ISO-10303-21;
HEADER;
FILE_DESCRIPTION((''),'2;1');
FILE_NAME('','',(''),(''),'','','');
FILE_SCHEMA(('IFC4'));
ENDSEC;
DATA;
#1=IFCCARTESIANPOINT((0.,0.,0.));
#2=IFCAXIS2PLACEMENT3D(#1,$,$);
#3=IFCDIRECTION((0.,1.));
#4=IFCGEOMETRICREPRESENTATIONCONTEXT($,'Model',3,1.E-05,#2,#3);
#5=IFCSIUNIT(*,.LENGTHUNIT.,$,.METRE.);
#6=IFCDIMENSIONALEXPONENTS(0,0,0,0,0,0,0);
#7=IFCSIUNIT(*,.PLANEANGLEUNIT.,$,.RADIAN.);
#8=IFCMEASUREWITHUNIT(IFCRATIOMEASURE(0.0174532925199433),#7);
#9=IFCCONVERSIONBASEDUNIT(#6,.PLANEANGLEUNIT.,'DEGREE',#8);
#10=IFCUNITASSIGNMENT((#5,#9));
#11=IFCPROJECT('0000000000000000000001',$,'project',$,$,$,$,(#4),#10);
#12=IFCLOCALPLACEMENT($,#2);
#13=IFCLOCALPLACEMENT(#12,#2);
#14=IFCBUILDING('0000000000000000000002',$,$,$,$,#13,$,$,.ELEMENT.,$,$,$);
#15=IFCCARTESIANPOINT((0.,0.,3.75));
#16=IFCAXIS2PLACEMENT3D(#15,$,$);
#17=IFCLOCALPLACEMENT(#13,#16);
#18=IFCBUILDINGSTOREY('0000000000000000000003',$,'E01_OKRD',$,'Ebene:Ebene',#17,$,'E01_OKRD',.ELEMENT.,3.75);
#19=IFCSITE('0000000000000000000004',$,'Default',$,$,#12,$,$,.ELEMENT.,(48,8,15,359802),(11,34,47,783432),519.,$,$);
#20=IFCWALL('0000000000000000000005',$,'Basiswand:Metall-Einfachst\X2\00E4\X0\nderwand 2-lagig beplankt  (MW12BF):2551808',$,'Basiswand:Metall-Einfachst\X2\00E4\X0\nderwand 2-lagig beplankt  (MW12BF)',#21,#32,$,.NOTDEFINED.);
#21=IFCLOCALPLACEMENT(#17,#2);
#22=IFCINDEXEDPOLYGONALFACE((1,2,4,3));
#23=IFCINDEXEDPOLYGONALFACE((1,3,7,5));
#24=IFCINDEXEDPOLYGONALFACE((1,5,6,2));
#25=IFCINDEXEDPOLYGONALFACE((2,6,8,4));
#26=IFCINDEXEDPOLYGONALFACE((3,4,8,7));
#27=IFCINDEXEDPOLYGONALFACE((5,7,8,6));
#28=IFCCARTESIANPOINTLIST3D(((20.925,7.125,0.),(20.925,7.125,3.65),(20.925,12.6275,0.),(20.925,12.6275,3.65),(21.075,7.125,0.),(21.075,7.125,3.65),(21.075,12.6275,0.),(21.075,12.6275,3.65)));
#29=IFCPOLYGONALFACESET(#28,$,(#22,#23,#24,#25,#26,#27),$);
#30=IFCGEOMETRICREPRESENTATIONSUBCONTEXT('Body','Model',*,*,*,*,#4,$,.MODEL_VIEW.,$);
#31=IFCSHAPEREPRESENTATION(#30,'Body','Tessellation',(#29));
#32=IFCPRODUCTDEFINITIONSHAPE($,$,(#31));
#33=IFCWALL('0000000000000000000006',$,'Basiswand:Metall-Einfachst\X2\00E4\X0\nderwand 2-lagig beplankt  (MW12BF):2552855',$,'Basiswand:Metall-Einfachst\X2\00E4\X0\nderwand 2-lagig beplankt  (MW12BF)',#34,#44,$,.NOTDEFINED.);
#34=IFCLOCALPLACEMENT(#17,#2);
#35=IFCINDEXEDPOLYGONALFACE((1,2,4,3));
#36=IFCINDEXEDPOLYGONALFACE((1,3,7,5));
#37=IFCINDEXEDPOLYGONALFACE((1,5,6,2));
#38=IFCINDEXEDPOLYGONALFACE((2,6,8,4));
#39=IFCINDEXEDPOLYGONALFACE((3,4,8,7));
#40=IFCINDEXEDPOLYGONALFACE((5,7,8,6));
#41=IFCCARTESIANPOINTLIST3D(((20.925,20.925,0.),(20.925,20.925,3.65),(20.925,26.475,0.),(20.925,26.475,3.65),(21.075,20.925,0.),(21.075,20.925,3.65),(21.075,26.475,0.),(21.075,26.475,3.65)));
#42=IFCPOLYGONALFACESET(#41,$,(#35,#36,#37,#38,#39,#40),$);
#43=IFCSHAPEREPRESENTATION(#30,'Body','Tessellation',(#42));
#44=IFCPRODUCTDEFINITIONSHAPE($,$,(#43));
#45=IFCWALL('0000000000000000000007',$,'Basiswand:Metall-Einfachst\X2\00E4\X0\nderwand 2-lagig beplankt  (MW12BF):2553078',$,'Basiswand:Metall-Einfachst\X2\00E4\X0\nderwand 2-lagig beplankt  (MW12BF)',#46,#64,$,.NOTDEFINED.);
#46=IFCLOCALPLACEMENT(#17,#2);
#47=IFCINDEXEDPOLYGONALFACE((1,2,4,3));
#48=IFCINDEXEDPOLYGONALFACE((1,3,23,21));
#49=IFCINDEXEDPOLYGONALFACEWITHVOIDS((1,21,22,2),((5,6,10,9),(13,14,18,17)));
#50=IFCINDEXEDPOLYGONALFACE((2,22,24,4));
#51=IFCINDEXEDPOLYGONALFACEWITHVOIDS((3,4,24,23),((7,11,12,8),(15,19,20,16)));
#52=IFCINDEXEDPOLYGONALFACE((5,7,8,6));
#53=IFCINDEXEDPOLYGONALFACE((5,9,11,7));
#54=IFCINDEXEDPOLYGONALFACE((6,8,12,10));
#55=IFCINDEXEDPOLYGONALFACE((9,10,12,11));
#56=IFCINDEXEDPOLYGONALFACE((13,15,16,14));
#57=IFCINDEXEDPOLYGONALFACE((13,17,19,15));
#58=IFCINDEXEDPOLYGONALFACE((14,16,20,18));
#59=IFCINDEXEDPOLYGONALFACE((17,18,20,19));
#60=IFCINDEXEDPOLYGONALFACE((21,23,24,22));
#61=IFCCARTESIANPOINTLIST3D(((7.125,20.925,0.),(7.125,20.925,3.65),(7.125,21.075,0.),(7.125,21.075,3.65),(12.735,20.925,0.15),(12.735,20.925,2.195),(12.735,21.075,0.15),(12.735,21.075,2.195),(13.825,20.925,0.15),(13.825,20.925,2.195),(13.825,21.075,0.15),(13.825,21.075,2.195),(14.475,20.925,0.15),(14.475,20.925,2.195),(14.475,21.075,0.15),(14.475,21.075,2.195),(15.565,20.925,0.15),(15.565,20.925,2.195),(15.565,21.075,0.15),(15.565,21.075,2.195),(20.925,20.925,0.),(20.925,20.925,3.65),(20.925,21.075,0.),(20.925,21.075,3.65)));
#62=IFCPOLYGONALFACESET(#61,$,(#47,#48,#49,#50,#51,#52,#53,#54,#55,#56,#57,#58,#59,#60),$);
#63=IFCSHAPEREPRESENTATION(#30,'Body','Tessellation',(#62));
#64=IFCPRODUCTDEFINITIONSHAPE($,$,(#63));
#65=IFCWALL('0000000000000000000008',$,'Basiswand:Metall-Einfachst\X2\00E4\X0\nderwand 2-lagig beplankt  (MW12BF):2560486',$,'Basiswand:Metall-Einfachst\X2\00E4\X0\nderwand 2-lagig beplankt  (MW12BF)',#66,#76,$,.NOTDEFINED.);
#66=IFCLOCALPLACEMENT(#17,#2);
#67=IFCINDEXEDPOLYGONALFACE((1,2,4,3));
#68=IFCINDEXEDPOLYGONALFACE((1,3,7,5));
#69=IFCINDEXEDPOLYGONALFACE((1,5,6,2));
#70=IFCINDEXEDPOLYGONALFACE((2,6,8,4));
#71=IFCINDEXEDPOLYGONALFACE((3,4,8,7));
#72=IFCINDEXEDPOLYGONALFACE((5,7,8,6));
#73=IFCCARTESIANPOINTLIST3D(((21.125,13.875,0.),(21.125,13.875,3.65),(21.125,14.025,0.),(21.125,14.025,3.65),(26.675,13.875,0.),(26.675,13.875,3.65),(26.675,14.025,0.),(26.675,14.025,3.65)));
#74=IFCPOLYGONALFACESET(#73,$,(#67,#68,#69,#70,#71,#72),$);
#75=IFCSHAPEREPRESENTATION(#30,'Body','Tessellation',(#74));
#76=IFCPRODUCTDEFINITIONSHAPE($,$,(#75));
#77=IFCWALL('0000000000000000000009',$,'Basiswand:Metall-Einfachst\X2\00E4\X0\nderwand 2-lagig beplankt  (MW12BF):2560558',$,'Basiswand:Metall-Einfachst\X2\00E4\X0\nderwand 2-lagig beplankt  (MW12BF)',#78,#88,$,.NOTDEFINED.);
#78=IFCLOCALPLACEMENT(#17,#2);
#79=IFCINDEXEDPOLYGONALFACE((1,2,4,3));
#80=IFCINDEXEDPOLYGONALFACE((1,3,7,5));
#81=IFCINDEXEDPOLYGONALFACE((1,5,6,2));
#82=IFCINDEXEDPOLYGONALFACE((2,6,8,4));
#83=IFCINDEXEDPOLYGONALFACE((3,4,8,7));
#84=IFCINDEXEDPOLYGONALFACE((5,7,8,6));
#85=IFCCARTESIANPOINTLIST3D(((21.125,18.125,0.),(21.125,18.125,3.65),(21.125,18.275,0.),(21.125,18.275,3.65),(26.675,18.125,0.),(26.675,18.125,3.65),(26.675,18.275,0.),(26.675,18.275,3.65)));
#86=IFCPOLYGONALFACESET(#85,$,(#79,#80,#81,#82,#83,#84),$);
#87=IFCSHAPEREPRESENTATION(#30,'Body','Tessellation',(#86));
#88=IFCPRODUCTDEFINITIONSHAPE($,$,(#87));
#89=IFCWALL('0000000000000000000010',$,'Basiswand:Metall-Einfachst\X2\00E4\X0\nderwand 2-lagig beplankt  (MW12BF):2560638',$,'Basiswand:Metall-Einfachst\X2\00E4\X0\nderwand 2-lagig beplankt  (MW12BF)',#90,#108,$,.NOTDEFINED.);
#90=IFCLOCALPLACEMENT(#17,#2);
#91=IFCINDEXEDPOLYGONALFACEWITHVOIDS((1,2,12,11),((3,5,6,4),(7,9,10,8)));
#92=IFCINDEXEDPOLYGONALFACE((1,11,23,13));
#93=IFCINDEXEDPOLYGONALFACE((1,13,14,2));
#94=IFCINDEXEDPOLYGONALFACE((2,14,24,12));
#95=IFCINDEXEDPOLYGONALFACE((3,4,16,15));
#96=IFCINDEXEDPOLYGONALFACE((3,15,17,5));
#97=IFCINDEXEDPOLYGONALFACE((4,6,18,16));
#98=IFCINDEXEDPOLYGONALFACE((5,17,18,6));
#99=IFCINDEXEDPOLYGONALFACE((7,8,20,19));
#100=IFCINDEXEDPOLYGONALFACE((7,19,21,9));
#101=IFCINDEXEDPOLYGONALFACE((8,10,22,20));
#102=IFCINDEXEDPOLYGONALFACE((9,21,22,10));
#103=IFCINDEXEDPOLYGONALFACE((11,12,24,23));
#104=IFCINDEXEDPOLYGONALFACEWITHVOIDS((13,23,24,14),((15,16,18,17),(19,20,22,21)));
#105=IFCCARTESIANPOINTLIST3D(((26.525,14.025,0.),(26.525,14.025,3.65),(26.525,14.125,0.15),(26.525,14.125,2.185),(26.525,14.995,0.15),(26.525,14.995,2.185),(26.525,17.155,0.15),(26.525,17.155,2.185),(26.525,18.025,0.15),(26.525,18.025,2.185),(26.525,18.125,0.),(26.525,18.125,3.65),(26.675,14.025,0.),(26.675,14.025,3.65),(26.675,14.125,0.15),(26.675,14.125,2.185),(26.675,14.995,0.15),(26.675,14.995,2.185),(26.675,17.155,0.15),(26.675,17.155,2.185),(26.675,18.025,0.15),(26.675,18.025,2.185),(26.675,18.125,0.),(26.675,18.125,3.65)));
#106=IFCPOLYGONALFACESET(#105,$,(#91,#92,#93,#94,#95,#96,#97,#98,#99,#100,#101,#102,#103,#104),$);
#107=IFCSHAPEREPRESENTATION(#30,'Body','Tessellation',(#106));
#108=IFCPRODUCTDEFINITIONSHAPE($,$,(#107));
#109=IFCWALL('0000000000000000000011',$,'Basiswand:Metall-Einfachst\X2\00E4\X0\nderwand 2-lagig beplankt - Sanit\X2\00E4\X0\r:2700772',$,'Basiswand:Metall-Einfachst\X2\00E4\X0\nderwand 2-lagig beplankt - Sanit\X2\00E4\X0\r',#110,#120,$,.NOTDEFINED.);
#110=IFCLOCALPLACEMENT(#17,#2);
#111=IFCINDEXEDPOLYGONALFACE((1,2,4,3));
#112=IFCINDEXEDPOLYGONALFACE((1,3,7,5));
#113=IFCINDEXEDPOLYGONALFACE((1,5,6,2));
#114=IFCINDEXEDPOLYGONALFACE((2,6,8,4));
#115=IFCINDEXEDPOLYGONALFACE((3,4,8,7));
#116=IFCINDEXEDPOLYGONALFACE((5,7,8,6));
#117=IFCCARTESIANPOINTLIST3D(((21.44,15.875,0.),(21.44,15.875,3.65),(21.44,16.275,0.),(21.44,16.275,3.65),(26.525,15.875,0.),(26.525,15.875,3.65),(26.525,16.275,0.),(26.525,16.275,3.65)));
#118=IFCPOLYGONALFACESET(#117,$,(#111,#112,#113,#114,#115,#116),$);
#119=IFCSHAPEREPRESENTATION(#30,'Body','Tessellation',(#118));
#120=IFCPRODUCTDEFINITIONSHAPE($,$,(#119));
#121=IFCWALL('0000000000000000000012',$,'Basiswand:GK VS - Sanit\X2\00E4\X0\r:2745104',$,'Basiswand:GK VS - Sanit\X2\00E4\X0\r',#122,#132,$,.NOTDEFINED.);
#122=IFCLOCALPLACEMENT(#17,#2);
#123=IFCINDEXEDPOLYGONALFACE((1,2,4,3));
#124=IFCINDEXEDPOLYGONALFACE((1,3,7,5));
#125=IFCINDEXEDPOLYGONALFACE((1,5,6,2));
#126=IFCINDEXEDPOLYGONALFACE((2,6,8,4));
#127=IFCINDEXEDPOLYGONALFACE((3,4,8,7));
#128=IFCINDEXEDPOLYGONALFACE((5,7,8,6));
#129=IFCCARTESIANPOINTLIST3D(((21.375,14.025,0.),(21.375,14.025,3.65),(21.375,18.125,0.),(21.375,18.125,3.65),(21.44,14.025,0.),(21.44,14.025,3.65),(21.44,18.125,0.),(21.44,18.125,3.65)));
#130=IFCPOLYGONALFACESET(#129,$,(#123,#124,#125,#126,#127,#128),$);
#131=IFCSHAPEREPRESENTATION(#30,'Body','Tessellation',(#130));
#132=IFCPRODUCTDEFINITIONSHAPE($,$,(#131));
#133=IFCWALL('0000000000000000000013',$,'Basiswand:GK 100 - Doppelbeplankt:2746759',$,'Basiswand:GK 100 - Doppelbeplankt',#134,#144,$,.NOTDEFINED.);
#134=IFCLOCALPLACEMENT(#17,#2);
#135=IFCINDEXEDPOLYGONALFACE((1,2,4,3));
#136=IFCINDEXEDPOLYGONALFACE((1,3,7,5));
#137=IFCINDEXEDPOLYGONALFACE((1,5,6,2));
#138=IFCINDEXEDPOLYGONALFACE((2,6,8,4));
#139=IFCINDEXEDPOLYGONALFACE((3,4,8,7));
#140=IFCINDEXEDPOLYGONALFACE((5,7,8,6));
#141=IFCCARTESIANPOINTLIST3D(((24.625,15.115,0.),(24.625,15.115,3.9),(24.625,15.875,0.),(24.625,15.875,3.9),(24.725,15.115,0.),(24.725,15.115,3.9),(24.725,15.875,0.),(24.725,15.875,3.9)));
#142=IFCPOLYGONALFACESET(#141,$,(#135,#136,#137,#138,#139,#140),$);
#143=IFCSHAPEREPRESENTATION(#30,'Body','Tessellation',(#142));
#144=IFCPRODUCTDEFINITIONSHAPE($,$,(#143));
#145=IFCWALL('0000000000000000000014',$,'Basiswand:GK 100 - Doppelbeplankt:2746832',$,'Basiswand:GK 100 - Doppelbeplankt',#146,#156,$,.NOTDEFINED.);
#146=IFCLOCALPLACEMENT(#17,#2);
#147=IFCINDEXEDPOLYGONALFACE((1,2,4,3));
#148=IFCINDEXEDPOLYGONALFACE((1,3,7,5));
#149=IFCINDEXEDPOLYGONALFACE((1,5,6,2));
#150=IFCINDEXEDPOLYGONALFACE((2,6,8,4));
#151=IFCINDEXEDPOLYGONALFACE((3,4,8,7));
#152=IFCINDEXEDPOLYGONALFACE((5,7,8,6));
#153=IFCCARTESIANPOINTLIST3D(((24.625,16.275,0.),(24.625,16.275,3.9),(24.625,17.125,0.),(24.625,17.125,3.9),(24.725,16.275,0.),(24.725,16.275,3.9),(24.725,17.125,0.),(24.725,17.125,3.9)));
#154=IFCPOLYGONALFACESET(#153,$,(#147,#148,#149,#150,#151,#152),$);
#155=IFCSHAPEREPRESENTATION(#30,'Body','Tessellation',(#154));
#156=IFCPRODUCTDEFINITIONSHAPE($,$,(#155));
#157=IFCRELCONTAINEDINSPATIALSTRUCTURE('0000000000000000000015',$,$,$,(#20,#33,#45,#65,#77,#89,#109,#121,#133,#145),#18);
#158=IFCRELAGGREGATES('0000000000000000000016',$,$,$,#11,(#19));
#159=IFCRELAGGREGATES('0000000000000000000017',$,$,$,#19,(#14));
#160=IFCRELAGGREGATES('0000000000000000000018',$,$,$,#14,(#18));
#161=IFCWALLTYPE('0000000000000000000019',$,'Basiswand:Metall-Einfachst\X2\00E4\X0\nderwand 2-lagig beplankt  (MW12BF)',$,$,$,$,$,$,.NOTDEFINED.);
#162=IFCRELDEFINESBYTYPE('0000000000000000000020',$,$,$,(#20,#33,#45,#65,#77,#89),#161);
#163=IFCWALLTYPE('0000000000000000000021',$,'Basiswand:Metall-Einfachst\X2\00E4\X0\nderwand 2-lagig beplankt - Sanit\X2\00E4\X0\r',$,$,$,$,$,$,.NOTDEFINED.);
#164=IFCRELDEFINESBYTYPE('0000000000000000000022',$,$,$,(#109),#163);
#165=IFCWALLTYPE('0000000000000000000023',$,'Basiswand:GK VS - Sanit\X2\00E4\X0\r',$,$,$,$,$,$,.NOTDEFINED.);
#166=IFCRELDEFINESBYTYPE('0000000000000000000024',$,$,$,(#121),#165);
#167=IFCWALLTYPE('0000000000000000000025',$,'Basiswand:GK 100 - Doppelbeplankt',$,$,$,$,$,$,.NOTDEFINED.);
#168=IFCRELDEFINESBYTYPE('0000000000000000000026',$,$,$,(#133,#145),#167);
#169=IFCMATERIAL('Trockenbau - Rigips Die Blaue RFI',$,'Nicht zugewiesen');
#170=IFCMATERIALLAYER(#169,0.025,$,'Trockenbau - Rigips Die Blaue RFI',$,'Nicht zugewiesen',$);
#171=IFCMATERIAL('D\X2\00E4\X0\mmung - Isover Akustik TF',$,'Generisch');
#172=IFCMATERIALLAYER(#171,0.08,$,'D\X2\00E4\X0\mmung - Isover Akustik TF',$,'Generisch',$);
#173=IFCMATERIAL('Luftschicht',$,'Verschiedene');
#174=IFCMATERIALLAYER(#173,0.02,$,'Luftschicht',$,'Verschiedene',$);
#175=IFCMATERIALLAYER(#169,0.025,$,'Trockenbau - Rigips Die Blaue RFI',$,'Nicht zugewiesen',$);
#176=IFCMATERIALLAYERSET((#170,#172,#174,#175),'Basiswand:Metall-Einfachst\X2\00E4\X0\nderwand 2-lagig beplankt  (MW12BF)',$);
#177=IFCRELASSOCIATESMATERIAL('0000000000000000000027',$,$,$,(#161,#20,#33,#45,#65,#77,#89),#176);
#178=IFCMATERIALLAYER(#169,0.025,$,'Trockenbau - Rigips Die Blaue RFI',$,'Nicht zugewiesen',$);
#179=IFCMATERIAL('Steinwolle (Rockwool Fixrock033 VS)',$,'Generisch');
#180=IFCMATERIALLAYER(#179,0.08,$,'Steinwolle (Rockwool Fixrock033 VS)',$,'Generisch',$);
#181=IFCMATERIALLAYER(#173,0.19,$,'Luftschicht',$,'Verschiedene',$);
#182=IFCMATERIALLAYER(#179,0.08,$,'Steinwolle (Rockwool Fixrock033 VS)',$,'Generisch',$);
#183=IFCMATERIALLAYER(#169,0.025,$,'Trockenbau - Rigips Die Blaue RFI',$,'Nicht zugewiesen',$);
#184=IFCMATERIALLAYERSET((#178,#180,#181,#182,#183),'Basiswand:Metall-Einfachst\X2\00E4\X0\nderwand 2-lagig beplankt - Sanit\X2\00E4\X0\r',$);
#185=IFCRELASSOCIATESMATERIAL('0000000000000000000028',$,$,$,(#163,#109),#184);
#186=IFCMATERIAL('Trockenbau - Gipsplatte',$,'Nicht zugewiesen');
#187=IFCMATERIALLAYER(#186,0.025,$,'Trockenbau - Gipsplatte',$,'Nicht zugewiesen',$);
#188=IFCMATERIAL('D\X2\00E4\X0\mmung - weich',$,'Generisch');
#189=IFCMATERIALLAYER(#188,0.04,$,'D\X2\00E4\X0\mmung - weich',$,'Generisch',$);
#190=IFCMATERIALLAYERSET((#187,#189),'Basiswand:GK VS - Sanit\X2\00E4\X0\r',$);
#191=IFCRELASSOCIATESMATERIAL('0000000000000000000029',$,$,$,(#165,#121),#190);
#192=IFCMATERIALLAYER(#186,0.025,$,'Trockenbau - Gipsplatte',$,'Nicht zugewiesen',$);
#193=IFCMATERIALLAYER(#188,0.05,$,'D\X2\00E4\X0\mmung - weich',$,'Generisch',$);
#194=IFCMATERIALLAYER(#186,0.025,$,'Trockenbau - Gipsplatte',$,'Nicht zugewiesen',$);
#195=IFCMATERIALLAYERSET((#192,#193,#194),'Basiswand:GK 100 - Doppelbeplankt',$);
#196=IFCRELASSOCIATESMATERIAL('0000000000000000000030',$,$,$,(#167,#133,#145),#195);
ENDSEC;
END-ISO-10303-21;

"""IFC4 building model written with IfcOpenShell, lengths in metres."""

from ifc_helpers import new_model, entity, si_unit, converted_unit, direction, frame, frame_2d, origin, place, context, subcontext, project, spatial, rectangle, extrude, material, layer, layer_set, layer_usage, type_object, element, save


model = new_model("IFC4")

# Units and contexts
model_context = context("Model", 3, precision=1e-05, world=origin(), true_north=direction((0.0, 1.0)))
body_context = subcontext(model_context, "Body", "Model", "MODEL_VIEW")
ifc_project = project(units=[si_unit("LENGTHUNIT", "METRE"), converted_unit("PLANEANGLEUNIT", "DEGREE", entity("IfcRatioMeasure", 0.0174532925199433), si_unit("PLANEANGLEUNIT", "RADIAN"), dimensions=[0, 0, 0, 0, 0, 0, 0])], contexts=[model_context])

# Site, building, storey
site_placement = place(None, frame((0.0, 0.0, 0.0)))
site = spatial("IfcSite", under=ifc_project, at=site_placement, Name="Default", CompositionType="ELEMENT", RefLatitude=(48, 8, 15, 359802), RefLongitude=(11, 34, 47, 783432), RefElevation=519.0)
building_placement = place(site_placement, origin())
building = spatial("IfcBuilding", under=site, at=building_placement, CompositionType="ELEMENT")
storey_placement = place(building_placement, frame((0.0, 0.0, 3.75)))
storey = spatial("IfcBuildingStorey", under=building, at=storey_placement, Name="E01_OKRD", ObjectType="Ebene:Ebene", LongName="E01_OKRD", CompositionType="ELEMENT", Elevation=3.75)

# Walls
ifc_material_1 = material(Name="Trockenbau - Rigips Die Blaue RFI", Category="Nicht zugewiesen")
ifc_layer_1 = layer(ifc_material_1, 0.025, Name="Trockenbau - Rigips Die Blaue RFI", Category="Nicht zugewiesen")
ifc_material_2 = material(Name="Dämmung - Isover Akustik TF", Category="Generisch")
ifc_layer_2 = layer(ifc_material_2, 0.08, Name="Dämmung - Isover Akustik TF", Category="Generisch")
ifc_material_3 = material(Name="Luftschicht", Category="Verschiedene")
ifc_layer_3 = layer(ifc_material_3, 0.02, Name="Luftschicht", Category="Verschiedene")
ifc_layer_4 = layer(ifc_material_1, 0.025, Name="Trockenbau - Rigips Die Blaue RFI", Category="Nicht zugewiesen")
ifc_layer_set_1 = layer_set([ifc_layer_1, ifc_layer_2, ifc_layer_3, ifc_layer_4], Name="Basiswand:Metall-Einfachständerwand 2-lagig beplankt  (MW12BF)")
ifc_layer_usage_1 = layer_usage(ifc_layer_set_1, "AXIS2", "NEGATIVE", 0.075)
wall_type_1 = type_object("IfcWallType", Name="Basiswand:Metall-Einfachständerwand 2-lagig beplankt  (MW12BF)", PredefinedType="NOTDEFINED", material=ifc_layer_set_1)
wall_1_placement = place(storey_placement, frame((21.0, 7.125, 0.0), z_axis=(0.0, 0.0, 1.0), x_axis=(0.0, 1.0, 0.0)))
element("IfcWall", 1, at=wall_1_placement, inside=storey, type_object=wall_type_1, material=ifc_layer_usage_1, Name="Basiswand:Metall-Einfachständerwand 2-lagig beplankt  (MW12BF):2551808", ObjectType="Basiswand:Metall-Einfachständerwand 2-lagig beplankt  (MW12BF)", PredefinedType="NOTDEFINED", context=body_context, shape_type="SweptSolid", body=[
    extrude(rectangle(XDim=5.5025, YDim=0.15, at=frame_2d((2.7513, 0.0), x_axis=(-1.0, 0.0))), origin(), (0.0, 0.0, 1.0), 3.65),
])
ifc_layer_usage_2 = layer_usage(ifc_layer_set_1, "AXIS2", "NEGATIVE", 0.075)
wall_2_placement = place(storey_placement, frame((21.0, 20.925, 0.0), z_axis=(0.0, 0.0, 1.0), x_axis=(0.0, 1.0, 0.0)))
element("IfcWall", 2, at=wall_2_placement, inside=storey, type_object=wall_type_1, material=ifc_layer_usage_2, Name="Basiswand:Metall-Einfachständerwand 2-lagig beplankt  (MW12BF):2552855", ObjectType="Basiswand:Metall-Einfachständerwand 2-lagig beplankt  (MW12BF)", PredefinedType="NOTDEFINED", context=body_context, shape_type="SweptSolid", body=[
    extrude(rectangle(XDim=5.55, YDim=0.15, at=frame_2d((2.775, 0.0), x_axis=(-1.0, 0.0))), origin(), (0.0, 0.0, 1.0), 3.65),
])

# Wall, openings
ifc_layer_usage_3 = layer_usage(ifc_layer_set_1, "AXIS2", "NEGATIVE", 0.075)
wall_3_placement = place(storey_placement, frame((20.925, 21.0, 0.0), z_axis=(0.0, 0.0, 1.0), x_axis=(-1.0, 0.0, 0.0)))
wall_3 = element("IfcWall", 3, at=wall_3_placement, inside=storey, type_object=wall_type_1, material=ifc_layer_usage_3, Name="Basiswand:Metall-Einfachständerwand 2-lagig beplankt  (MW12BF):2553078", ObjectType="Basiswand:Metall-Einfachständerwand 2-lagig beplankt  (MW12BF)", PredefinedType="NOTDEFINED", context=body_context, shape_type="SweptSolid", body=[
    extrude(rectangle(XDim=13.8, YDim=0.15, at=frame_2d((6.9, 0.0), x_axis=(-1.0, 0.0))), origin(), (0.0, 0.0, 1.0), 3.65),
])
opening_1_placement = place(wall_3_placement, frame((8.19, 0.075, 0.15)))
element("IfcOpeningElement", 4, at=opening_1_placement, cuts=wall_3, ObjectType="Opening", PredefinedType="OPENING", context=body_context, shape_type="SweptSolid", body=[
    extrude(rectangle(XDim=2.045, YDim=1.09, at=frame_2d((1.0225, 0.545), x_axis=(-1.0, 0.0))), frame((0.0, 0.0, 0.0), z_axis=(0.0, -1.0, 0.0), x_axis=(0.0, 0.0, 1.0)), (0.0, 0.0, 1.0), 0.15),
])
opening_2_placement = place(wall_3_placement, frame((6.45, 0.075, 0.15)))
element("IfcOpeningElement", 5, at=opening_2_placement, cuts=wall_3, ObjectType="Opening", PredefinedType="OPENING", context=body_context, shape_type="SweptSolid", body=[
    extrude(rectangle(XDim=2.045, YDim=1.09, at=frame_2d((1.0225, 0.545), x_axis=(-1.0, 0.0))), frame((0.0, 0.0, 0.0), z_axis=(0.0, -1.0, 0.0), x_axis=(0.0, 0.0, 1.0)), (0.0, 0.0, 1.0), 0.15),
])

# Walls
ifc_layer_usage_4 = layer_usage(ifc_layer_set_1, "AXIS2", "POSITIVE", -0.075)
wall_4_placement = place(storey_placement, frame((21.125, 13.95, 0.0)))
element("IfcWall", 6, at=wall_4_placement, inside=storey, type_object=wall_type_1, material=ifc_layer_usage_4, Name="Basiswand:Metall-Einfachständerwand 2-lagig beplankt  (MW12BF):2560486", ObjectType="Basiswand:Metall-Einfachständerwand 2-lagig beplankt  (MW12BF)", PredefinedType="NOTDEFINED", context=body_context, shape_type="SweptSolid", body=[
    extrude(rectangle(XDim=5.55, YDim=0.15, at=frame_2d((2.775, 0.0), x_axis=(-1.0, 0.0))), origin(), (0.0, 0.0, 1.0), 3.65),
])
ifc_layer_usage_5 = layer_usage(ifc_layer_set_1, "AXIS2", "NEGATIVE", 0.075)
wall_5_placement = place(storey_placement, frame((21.125, 18.2, 0.0)))
element("IfcWall", 7, at=wall_5_placement, inside=storey, type_object=wall_type_1, material=ifc_layer_usage_5, Name="Basiswand:Metall-Einfachständerwand 2-lagig beplankt  (MW12BF):2560558", ObjectType="Basiswand:Metall-Einfachständerwand 2-lagig beplankt  (MW12BF)", PredefinedType="NOTDEFINED", context=body_context, shape_type="SweptSolid", body=[
    extrude(rectangle(XDim=5.55, YDim=0.15, at=frame_2d((2.775, 0.0), x_axis=(-1.0, 0.0))), origin(), (0.0, 0.0, 1.0), 3.65),
])

# Wall, openings
ifc_layer_usage_6 = layer_usage(ifc_layer_set_1, "AXIS2", "NEGATIVE", 0.075)
wall_6_placement = place(storey_placement, frame((26.6, 18.125, 0.0), z_axis=(0.0, 0.0, 1.0), x_axis=(0.0, -1.0, 0.0)))
wall_6 = element("IfcWall", 8, at=wall_6_placement, inside=storey, type_object=wall_type_1, material=ifc_layer_usage_6, Name="Basiswand:Metall-Einfachständerwand 2-lagig beplankt  (MW12BF):2560638", ObjectType="Basiswand:Metall-Einfachständerwand 2-lagig beplankt  (MW12BF)", PredefinedType="NOTDEFINED", context=body_context, shape_type="SweptSolid", body=[
    extrude(rectangle(XDim=4.1, YDim=0.15, at=frame_2d((2.05, 0.0), x_axis=(-1.0, 0.0))), origin(), (0.0, 0.0, 1.0), 3.65),
])
opening_3_placement = place(wall_6_placement, frame((4.0, 0.075, 0.15)))
element("IfcOpeningElement", 9, at=opening_3_placement, cuts=wall_6, ObjectType="Opening", PredefinedType="OPENING", context=body_context, shape_type="SweptSolid", body=[
    extrude(rectangle(XDim=2.035, YDim=0.87, at=frame_2d((1.0175, 0.435), x_axis=(-1.0, 0.0))), frame((0.0, 0.0, 0.0), z_axis=(0.0, -1.0, 0.0), x_axis=(0.0, 0.0, 1.0)), (0.0, 0.0, 1.0), 0.15),
])
opening_4_placement = place(wall_6_placement, frame((0.97, 0.075, 0.15)))
element("IfcOpeningElement", 10, at=opening_4_placement, cuts=wall_6, ObjectType="Opening", PredefinedType="OPENING", context=body_context, shape_type="SweptSolid", body=[
    extrude(rectangle(XDim=2.035, YDim=0.87, at=frame_2d((1.0175, 0.435), x_axis=(-1.0, 0.0))), frame((0.0, 0.0, 0.0), z_axis=(0.0, -1.0, 0.0), x_axis=(0.0, 0.0, 1.0)), (0.0, 0.0, 1.0), 0.15),
])

# Walls
ifc_layer_5 = layer(ifc_material_1, 0.025, Name="Trockenbau - Rigips Die Blaue RFI", Category="Nicht zugewiesen")
ifc_material_4 = material(Name="Steinwolle (Rockwool Fixrock033 VS)", Category="Generisch")
ifc_layer_6 = layer(ifc_material_4, 0.08, Name="Steinwolle (Rockwool Fixrock033 VS)", Category="Generisch")
ifc_layer_7 = layer(ifc_material_3, 0.19, Name="Luftschicht", Category="Verschiedene")
ifc_layer_8 = layer(ifc_material_4, 0.08, Name="Steinwolle (Rockwool Fixrock033 VS)", Category="Generisch")
ifc_layer_9 = layer(ifc_material_1, 0.025, Name="Trockenbau - Rigips Die Blaue RFI", Category="Nicht zugewiesen")
ifc_layer_set_2 = layer_set([ifc_layer_5, ifc_layer_6, ifc_layer_7, ifc_layer_8, ifc_layer_9], Name="Basiswand:Metall-Einfachständerwand 2-lagig beplankt - Sanitär")
ifc_layer_usage_7 = layer_usage(ifc_layer_set_2, "AXIS2", "NEGATIVE", 0.2)
wall_type_2 = type_object("IfcWallType", Name="Basiswand:Metall-Einfachständerwand 2-lagig beplankt - Sanitär", PredefinedType="NOTDEFINED", material=ifc_layer_set_2)
wall_7_placement = place(storey_placement, frame((21.44, 16.075, 0.0)))
element("IfcWall", 11, at=wall_7_placement, inside=storey, type_object=wall_type_2, material=ifc_layer_usage_7, Name="Basiswand:Metall-Einfachständerwand 2-lagig beplankt - Sanitär:2700772", ObjectType="Basiswand:Metall-Einfachständerwand 2-lagig beplankt - Sanitär", PredefinedType="NOTDEFINED", context=body_context, shape_type="SweptSolid", body=[
    extrude(rectangle(XDim=5.085, YDim=0.4, at=frame_2d((2.5425, 0.0), x_axis=(-1.0, 0.0))), origin(), (0.0, 0.0, 1.0), 3.65),
])
ifc_material_5 = material(Name="Trockenbau - Gipsplatte", Category="Nicht zugewiesen")
ifc_layer_10 = layer(ifc_material_5, 0.025, Name="Trockenbau - Gipsplatte", Category="Nicht zugewiesen")
ifc_material_6 = material(Name="Dämmung - weich", Category="Generisch")
ifc_layer_11 = layer(ifc_material_6, 0.04, Name="Dämmung - weich", Category="Generisch")
ifc_layer_set_3 = layer_set([ifc_layer_10, ifc_layer_11], Name="Basiswand:GK VS - Sanitär")
ifc_layer_usage_8 = layer_usage(ifc_layer_set_3, "AXIS2", "NEGATIVE", 0.0325)
wall_type_3 = type_object("IfcWallType", Name="Basiswand:GK VS - Sanitär", PredefinedType="NOTDEFINED", material=ifc_layer_set_3)
wall_8_placement = place(storey_placement, frame((21.4075, 18.125, 0.0), z_axis=(0.0, 0.0, 1.0), x_axis=(0.0, -1.0, 0.0)))
element("IfcWall", 12, at=wall_8_placement, inside=storey, type_object=wall_type_3, material=ifc_layer_usage_8, Name="Basiswand:GK VS - Sanitär:2745104", ObjectType="Basiswand:GK VS - Sanitär", PredefinedType="NOTDEFINED", context=body_context, shape_type="SweptSolid", body=[
    extrude(rectangle(XDim=4.1, YDim=0.065, at=frame_2d((2.05, 0.0), x_axis=(-1.0, 0.0))), origin(), (0.0, 0.0, 1.0), 3.65),
])
ifc_layer_12 = layer(ifc_material_5, 0.025, Name="Trockenbau - Gipsplatte", Category="Nicht zugewiesen")
ifc_layer_13 = layer(ifc_material_6, 0.05, Name="Dämmung - weich", Category="Generisch")
ifc_layer_14 = layer(ifc_material_5, 0.025, Name="Trockenbau - Gipsplatte", Category="Nicht zugewiesen")
ifc_layer_set_4 = layer_set([ifc_layer_12, ifc_layer_13, ifc_layer_14], Name="Basiswand:GK 100 - Doppelbeplankt")
ifc_layer_usage_9 = layer_usage(ifc_layer_set_4, "AXIS2", "NEGATIVE", 0.05)
wall_type_4 = type_object("IfcWallType", Name="Basiswand:GK 100 - Doppelbeplankt", PredefinedType="NOTDEFINED", material=ifc_layer_set_4)
wall_9_placement = place(storey_placement, frame((24.675, 15.875, 0.0), z_axis=(0.0, 0.0, 1.0), x_axis=(0.0, -1.0, 0.0)))
element("IfcWall", 13, at=wall_9_placement, inside=storey, type_object=wall_type_4, material=ifc_layer_usage_9, Name="Basiswand:GK 100 - Doppelbeplankt:2746759", ObjectType="Basiswand:GK 100 - Doppelbeplankt", PredefinedType="NOTDEFINED", context=body_context, shape_type="SweptSolid", body=[
    extrude(rectangle(XDim=0.76, YDim=0.1, at=frame_2d((0.38, 0.0), x_axis=(-1.0, 0.0))), origin(), (0.0, 0.0, 1.0), 3.9),
])
ifc_layer_usage_10 = layer_usage(ifc_layer_set_4, "AXIS2", "NEGATIVE", 0.05)
wall_10_placement = place(storey_placement, frame((24.675, 16.275, 0.0), z_axis=(0.0, 0.0, 1.0), x_axis=(0.0, 1.0, 0.0)))
element("IfcWall", 14, at=wall_10_placement, inside=storey, type_object=wall_type_4, material=ifc_layer_usage_10, Name="Basiswand:GK 100 - Doppelbeplankt:2746832", ObjectType="Basiswand:GK 100 - Doppelbeplankt", PredefinedType="NOTDEFINED", context=body_context, shape_type="SweptSolid", body=[
    extrude(rectangle(XDim=0.85, YDim=0.1, at=frame_2d((0.425, 0.0), x_axis=(-1.0, 0.0))), origin(), (0.0, 0.0, 1.0), 3.9),
])

save(model, "model.ifc")
